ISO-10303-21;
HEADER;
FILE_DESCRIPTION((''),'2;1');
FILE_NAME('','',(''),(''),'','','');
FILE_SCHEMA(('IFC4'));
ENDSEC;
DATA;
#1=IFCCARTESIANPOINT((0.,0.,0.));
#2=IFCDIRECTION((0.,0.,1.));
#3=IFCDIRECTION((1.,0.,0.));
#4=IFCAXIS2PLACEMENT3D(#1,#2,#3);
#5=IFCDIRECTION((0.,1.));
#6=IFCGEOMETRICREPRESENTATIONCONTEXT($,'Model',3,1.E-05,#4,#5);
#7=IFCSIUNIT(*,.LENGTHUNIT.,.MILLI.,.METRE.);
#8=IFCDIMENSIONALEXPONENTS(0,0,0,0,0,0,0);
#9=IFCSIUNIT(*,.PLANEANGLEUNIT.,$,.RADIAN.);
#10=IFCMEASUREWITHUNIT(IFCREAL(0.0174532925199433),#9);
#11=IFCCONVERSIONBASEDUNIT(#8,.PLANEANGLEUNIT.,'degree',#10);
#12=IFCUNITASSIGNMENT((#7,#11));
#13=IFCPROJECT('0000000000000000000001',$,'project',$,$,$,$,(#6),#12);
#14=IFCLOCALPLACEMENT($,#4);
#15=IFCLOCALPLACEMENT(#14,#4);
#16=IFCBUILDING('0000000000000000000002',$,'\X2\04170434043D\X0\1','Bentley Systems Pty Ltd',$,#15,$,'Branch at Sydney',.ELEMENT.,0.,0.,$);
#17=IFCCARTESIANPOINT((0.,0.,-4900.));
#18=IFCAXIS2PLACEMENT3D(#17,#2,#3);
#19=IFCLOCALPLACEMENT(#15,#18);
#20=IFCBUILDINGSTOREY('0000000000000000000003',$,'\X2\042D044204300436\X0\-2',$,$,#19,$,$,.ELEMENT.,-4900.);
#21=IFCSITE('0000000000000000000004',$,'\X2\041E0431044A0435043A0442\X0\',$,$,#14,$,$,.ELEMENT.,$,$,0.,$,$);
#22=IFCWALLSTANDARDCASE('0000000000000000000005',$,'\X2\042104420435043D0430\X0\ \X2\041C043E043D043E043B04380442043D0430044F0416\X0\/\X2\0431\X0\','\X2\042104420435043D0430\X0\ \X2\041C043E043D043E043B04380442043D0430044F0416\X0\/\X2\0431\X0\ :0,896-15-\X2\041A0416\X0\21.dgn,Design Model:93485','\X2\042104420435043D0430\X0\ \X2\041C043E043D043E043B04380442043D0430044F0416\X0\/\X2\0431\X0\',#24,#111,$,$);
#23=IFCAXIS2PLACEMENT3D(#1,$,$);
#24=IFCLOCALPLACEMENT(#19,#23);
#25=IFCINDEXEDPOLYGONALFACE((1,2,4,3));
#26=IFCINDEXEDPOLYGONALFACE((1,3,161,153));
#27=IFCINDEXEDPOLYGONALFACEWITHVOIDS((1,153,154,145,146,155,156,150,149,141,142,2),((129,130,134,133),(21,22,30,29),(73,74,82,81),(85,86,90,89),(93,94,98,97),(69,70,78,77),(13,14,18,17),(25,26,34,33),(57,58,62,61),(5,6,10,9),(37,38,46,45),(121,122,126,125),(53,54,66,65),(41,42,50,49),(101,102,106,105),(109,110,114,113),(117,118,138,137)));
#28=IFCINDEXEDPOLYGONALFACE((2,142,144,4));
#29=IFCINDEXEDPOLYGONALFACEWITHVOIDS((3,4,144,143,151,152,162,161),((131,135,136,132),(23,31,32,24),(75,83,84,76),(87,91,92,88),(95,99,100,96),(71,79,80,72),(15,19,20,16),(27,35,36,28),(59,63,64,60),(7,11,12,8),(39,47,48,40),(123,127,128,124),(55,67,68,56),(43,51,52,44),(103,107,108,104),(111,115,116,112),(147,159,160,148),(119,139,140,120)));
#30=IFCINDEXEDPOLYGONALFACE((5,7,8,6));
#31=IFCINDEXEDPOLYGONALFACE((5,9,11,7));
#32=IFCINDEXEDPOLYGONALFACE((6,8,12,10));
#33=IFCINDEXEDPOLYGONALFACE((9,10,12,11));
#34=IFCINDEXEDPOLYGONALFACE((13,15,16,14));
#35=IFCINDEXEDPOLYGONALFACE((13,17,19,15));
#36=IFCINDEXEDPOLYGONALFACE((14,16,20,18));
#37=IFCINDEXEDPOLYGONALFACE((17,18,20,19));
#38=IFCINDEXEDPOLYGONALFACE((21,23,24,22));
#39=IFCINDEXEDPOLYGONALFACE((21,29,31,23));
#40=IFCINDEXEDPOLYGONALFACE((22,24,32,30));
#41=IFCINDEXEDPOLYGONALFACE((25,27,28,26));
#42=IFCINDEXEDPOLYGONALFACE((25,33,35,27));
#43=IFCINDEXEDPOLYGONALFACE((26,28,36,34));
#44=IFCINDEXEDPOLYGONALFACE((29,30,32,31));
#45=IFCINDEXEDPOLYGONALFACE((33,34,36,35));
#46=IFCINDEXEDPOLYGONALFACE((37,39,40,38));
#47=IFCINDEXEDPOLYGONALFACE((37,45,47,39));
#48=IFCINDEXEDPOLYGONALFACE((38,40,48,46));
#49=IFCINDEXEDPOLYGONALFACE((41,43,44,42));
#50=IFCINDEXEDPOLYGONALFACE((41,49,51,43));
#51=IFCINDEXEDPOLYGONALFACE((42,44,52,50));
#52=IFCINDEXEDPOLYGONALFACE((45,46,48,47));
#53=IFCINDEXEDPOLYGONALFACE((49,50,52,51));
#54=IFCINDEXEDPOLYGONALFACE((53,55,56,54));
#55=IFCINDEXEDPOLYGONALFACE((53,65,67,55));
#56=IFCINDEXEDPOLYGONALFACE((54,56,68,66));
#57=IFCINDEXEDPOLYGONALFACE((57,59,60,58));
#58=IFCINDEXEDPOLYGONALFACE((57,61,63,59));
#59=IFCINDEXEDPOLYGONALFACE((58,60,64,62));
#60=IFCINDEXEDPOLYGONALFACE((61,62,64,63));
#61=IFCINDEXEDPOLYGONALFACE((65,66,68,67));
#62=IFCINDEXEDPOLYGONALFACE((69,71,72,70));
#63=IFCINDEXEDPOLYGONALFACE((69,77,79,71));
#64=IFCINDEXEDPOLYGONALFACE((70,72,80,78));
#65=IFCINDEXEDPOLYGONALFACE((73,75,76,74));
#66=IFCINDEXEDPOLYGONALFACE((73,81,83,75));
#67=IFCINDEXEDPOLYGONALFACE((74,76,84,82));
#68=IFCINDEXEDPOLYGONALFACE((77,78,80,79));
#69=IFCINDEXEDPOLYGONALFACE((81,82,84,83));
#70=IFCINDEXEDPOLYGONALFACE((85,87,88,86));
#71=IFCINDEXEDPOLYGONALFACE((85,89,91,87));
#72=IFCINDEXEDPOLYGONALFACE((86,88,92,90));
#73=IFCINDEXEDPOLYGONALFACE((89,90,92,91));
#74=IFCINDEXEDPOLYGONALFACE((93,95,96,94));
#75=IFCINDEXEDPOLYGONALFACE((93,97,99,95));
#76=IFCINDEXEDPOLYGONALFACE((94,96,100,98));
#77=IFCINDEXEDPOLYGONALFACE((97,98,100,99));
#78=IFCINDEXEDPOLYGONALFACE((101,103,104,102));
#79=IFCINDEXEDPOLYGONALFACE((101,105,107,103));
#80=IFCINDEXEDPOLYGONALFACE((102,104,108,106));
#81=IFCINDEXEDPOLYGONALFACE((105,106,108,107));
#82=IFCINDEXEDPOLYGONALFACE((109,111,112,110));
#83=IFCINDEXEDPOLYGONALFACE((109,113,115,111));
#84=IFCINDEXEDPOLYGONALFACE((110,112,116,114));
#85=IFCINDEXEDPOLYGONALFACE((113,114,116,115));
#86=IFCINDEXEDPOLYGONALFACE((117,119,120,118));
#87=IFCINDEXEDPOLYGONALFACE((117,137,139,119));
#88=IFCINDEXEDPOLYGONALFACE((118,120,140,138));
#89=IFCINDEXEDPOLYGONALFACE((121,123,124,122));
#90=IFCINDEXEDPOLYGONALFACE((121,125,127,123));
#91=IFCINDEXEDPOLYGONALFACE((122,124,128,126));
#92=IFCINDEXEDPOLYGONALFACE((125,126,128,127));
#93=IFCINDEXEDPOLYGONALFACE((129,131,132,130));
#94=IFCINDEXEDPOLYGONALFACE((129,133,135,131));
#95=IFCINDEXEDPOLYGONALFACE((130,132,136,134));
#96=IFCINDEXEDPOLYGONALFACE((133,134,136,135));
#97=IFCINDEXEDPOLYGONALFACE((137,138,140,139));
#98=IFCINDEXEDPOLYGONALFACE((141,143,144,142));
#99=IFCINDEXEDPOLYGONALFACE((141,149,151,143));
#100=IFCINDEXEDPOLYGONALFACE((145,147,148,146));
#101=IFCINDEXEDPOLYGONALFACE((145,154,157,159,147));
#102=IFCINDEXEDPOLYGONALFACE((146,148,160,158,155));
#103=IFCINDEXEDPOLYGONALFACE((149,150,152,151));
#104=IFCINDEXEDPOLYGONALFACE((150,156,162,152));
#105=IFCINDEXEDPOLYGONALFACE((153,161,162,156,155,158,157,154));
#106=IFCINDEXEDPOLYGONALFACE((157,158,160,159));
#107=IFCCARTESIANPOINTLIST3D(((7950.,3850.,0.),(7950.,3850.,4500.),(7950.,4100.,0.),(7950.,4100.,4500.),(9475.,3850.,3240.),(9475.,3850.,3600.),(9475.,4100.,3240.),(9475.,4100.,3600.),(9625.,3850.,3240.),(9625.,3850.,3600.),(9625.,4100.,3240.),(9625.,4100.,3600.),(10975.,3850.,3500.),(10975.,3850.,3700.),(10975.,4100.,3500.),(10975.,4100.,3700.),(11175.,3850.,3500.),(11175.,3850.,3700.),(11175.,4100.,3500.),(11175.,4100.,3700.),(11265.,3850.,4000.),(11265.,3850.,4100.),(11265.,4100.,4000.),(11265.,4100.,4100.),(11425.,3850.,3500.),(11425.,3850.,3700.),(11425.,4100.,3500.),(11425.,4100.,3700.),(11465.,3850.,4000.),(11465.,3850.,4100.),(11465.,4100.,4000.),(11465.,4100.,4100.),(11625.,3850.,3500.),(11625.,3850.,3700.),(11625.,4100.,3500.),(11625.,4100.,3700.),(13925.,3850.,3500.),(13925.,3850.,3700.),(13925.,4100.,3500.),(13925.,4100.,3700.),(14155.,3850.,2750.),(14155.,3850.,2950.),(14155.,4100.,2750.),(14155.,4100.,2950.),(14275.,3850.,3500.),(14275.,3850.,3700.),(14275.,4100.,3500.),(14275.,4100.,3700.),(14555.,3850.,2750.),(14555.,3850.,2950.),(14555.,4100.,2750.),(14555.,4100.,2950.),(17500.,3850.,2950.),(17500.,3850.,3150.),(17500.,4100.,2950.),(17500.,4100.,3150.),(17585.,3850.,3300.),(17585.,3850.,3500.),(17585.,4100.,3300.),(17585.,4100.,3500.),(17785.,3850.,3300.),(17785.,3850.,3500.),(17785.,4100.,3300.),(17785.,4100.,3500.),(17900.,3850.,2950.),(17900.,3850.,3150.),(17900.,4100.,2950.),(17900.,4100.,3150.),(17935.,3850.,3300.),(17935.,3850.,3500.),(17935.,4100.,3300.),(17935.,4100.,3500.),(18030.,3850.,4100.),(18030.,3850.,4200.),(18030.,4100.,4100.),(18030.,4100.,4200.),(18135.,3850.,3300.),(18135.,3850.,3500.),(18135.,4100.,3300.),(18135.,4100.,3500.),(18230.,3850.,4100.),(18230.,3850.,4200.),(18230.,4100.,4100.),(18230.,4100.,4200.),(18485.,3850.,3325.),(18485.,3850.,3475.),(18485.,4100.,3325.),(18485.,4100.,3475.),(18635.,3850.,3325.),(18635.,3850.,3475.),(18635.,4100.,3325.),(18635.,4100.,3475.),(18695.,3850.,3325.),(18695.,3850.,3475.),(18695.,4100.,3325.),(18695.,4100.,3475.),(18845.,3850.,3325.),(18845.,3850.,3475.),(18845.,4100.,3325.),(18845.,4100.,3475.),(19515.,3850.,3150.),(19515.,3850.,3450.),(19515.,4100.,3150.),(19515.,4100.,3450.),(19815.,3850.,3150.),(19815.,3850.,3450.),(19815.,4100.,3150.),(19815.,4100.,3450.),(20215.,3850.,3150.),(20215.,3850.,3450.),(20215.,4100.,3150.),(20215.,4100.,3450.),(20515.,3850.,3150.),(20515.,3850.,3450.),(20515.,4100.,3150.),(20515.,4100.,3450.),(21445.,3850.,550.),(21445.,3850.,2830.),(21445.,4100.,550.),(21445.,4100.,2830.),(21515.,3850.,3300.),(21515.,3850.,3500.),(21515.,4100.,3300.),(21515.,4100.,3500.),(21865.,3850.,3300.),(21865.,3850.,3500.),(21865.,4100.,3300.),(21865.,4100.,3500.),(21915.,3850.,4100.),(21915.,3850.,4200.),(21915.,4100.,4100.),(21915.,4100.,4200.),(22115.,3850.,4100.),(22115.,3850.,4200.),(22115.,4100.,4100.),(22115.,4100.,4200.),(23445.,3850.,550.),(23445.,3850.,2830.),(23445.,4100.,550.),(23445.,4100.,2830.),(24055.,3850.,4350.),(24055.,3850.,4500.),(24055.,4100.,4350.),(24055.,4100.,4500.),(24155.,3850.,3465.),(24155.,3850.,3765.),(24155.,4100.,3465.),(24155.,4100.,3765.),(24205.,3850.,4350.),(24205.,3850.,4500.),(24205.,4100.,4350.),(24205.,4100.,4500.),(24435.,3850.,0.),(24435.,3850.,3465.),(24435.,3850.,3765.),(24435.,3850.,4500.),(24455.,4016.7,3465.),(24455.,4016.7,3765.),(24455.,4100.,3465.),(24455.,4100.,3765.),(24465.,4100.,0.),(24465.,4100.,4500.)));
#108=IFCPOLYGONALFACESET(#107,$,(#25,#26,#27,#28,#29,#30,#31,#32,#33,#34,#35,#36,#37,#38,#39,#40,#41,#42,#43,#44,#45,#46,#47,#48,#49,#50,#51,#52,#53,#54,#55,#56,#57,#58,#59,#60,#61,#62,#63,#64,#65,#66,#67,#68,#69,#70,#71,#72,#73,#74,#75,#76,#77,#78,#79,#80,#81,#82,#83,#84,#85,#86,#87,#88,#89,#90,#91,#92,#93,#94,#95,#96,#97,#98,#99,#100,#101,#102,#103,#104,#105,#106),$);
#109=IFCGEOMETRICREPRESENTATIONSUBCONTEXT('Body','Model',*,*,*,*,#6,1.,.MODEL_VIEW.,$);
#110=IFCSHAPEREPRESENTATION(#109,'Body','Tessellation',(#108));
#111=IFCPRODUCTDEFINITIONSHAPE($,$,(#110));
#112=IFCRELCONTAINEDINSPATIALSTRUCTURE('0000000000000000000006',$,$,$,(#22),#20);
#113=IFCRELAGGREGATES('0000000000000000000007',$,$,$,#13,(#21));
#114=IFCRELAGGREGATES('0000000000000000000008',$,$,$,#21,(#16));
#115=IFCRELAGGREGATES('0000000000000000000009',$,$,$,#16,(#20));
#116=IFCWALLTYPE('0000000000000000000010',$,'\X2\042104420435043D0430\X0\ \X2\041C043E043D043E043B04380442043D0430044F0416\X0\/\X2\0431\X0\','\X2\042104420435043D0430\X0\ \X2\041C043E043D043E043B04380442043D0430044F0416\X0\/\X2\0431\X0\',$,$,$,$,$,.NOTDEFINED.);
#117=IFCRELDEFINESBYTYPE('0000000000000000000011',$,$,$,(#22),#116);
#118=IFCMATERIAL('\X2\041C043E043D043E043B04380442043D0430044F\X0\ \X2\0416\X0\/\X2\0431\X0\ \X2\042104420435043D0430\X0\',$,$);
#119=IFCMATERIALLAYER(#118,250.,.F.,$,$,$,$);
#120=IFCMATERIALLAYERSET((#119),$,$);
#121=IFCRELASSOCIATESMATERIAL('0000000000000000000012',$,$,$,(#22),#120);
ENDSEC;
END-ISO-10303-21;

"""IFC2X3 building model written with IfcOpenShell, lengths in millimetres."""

from ifc_helpers import new_model, entity, si_unit, converted_unit, direction, frame, frame_2d, origin_with_axes, place, context, subcontext, project, spatial, polyline, rectangle, outline, extrude, material, layer, layer_set, layer_usage, type_object, element, save


model = new_model("IFC2X3")

# Units and contexts
model_context = context("Model", 3, precision=1e-05, world=origin_with_axes(), true_north=direction((0.0, 1.0)))
body_context = subcontext(model_context, "Body", "Model", "MODEL_VIEW", scale=1.0)
ifc_project = project(units=[si_unit("LENGTHUNIT", "METRE", prefix="MILLI"), converted_unit("PLANEANGLEUNIT", "degree", entity("IfcReal", 0.0174532925199433), si_unit("PLANEANGLEUNIT", "RADIAN"), dimensions=[0, 0, 0, 0, 0, 0, 0])], contexts=[model_context])

# Site, building, storey
site_placement = place(None, origin_with_axes())
site = spatial("IfcSite", under=ifc_project, at=site_placement, Name="Объект", CompositionType="ELEMENT", RefElevation=0.0)
building_placement = place(site_placement, origin_with_axes())
building = spatial("IfcBuilding", under=site, at=building_placement, Name="Здн1", Description="Bentley Systems Pty Ltd", LongName="Branch at Sydney", CompositionType="ELEMENT", ElevationOfRefHeight=0.0, ElevationOfTerrain=0.0)
storey_placement = place(building_placement, frame((0.0, 0.0, -4900.0), z_axis=(0.0, 0.0, 1.0), x_axis=(1.0, 0.0, 0.0)))
storey = spatial("IfcBuildingStorey", under=building, at=storey_placement, Name="Этаж-2", CompositionType="ELEMENT", Elevation=-4900.0)

# Wall, openings
ifc_material = material(Name="Монолитная Ж/б Стена")
ifc_layer_1 = layer(ifc_material, 250.0, ventilated=False)
ifc_layer_set_1 = layer_set([ifc_layer_1])
ifc_layer_usage_1 = layer_usage(ifc_layer_set_1, "AXIS2", "POSITIVE", 0.0)
wall_type = type_object("IfcWallType", Name="Стена МонолитнаяЖ/б", Description="Стена МонолитнаяЖ/б", PredefinedType="NOTDEFINED")
wall_1_placement = place(storey_placement, frame((7950.0, 3850.0, 0.0), z_axis=(0.0, 0.0, 1.0), x_axis=(1.0, 0.0, 0.0)))
wall_1 = element("IfcWallStandardCase", 1, at=wall_1_placement, inside=storey, type_object=wall_type, material=ifc_layer_usage_1, Name="Стена МонолитнаяЖ/б", Description="Стена МонолитнаяЖ/б :0,896-15-КЖ21.dgn,Design Model:93485", ObjectType="Стена МонолитнаяЖ/б", context=body_context, shape_type="SweptSolid", body=[
    extrude(outline(polyline([(16515.0, 250.0), (0.0, 250.0), (0.0, 0.0), (16485.0, 0.0), (16515.0, 250.0)])), origin_with_axes(), (0.0, 0.0, 1.0), 4500.0),
])
opening_1_placement = place(wall_1_placement, frame((13495.0, 0.0, 550.0), z_axis=(0.0, 0.0, 1.0), x_axis=(1.0, 0.0, 0.0)))
element("IfcOpeningElement", 2, at=opening_1_placement, cuts=wall_1, ObjectType="Opening", context=body_context, shape_type="SweptSolid", body=[
    extrude(rectangle(XDim=2280.0, YDim=2000.0, at=frame_2d((-1000.0, 1140.0), x_axis=(0.0, -1.0))), frame((0.0, 0.0, 0.0), z_axis=(0.0, 1.0, 0.0), x_axis=(-1.0, 0.0, 0.0)), (0.0, 0.0, 1.0), 250.0),
])
opening_2_placement = place(wall_1_placement, frame((1525.0, 0.0, 3240.0), z_axis=(0.0, 0.0, 1.0), x_axis=(1.0, 0.0, 0.0)))
element("IfcOpeningElement", 3, at=opening_2_placement, cuts=wall_1, ObjectType="Opening", context=body_context, shape_type="SweptSolid", body=[
    extrude(rectangle(XDim=360.0, YDim=150.0, at=frame_2d((-75.0, 180.0), x_axis=(0.0, -1.0))), frame((0.0, 0.0, 0.0), z_axis=(0.0, 1.0, 0.0), x_axis=(-1.0, 0.0, 0.0)), (0.0, 0.0, 1.0), 250.0),
])
opening_3_placement = place(wall_1_placement, frame((3025.0, 0.0, 3500.0), z_axis=(0.0, 0.0, 1.0), x_axis=(1.0, 0.0, 0.0)))
element("IfcOpeningElement", 4, at=opening_3_placement, cuts=wall_1, ObjectType="Opening", context=body_context, shape_type="SweptSolid", body=[
    extrude(rectangle(XDim=200.0, YDim=200.0, at=frame_2d((-100.0, 100.0), x_axis=(0.0, -1.0))), frame((0.0, 0.0, 0.0), z_axis=(0.0, 1.0, 0.0), x_axis=(-1.0, 0.0, 0.0)), (0.0, 0.0, 1.0), 250.0),
])
opening_4_placement = place(wall_1_placement, frame((3475.0, 0.0, 3500.0), z_axis=(0.0, 0.0, 1.0), x_axis=(1.0, 0.0, 0.0)))
element("IfcOpeningElement", 5, at=opening_4_placement, cuts=wall_1, ObjectType="Opening", context=body_context, shape_type="SweptSolid", body=[
    extrude(rectangle(XDim=200.0, YDim=200.0, at=frame_2d((-100.0, 100.0), x_axis=(0.0, -1.0))), frame((0.0, 0.0, 0.0), z_axis=(0.0, 1.0, 0.0), x_axis=(-1.0, 0.0, 0.0)), (0.0, 0.0, 1.0), 250.0),
])
opening_5_placement = place(wall_1_placement, frame((5975.0, 0.0, 3500.0), z_axis=(0.0, 0.0, 1.0), x_axis=(1.0, 0.0, 0.0)))
element("IfcOpeningElement", 6, at=opening_5_placement, cuts=wall_1, ObjectType="Opening", context=body_context, shape_type="SweptSolid", body=[
    extrude(rectangle(XDim=200.0, YDim=350.0, at=frame_2d((-175.0, 100.0), x_axis=(0.0, -1.0))), frame((0.0, 0.0, 0.0), z_axis=(0.0, 1.0, 0.0), x_axis=(-1.0, 0.0, 0.0)), (0.0, 0.0, 1.0), 250.0),
])
opening_6_placement = place(wall_1_placement, frame((3315.0, 0.0, 4000.0), z_axis=(0.0, 0.0, 1.0), x_axis=(1.0, 0.0, 0.0)))
element("IfcOpeningElement", 7, at=opening_6_placement, cuts=wall_1, ObjectType="Opening", context=body_context, shape_type="SweptSolid", body=[
    extrude(rectangle(XDim=100.0, YDim=200.0, at=frame_2d((-100.0, 50.0), x_axis=(0.0, -1.0))), frame((0.0, 0.0, 0.0), z_axis=(0.0, 1.0, 0.0), x_axis=(-1.0, 0.0, 0.0)), (0.0, 0.0, 1.0), 250.0),
])
opening_7_placement = place(wall_1_placement, frame((6205.0, 0.0, 2750.0), z_axis=(0.0, 0.0, 1.0), x_axis=(1.0, 0.0, 0.0)))
element("IfcOpeningElement", 8, at=opening_7_placement, cuts=wall_1, ObjectType="Opening", context=body_context, shape_type="SweptSolid", body=[
    extrude(rectangle(XDim=200.0, YDim=400.0, at=frame_2d((-200.0, 100.0), x_axis=(0.0, -1.0))), frame((0.0, 0.0, 0.0), z_axis=(0.0, 1.0, 0.0), x_axis=(-1.0, 0.0, 0.0)), (0.0, 0.0, 1.0), 250.0),
])
opening_8_placement = place(wall_1_placement, frame((9635.0, 0.0, 3300.0), z_axis=(0.0, 0.0, 1.0), x_axis=(1.0, 0.0, 0.0)))
element("IfcOpeningElement", 9, at=opening_8_placement, cuts=wall_1, ObjectType="Opening", context=body_context, shape_type="SweptSolid", body=[
    extrude(rectangle(XDim=200.0, YDim=200.0, at=frame_2d((-100.0, 100.0), x_axis=(0.0, -1.0))), frame((0.0, 0.0, 0.0), z_axis=(0.0, 1.0, 0.0), x_axis=(-1.0, 0.0, 0.0)), (0.0, 0.0, 1.0), 250.0),
])
opening_9_placement = place(wall_1_placement, frame((9985.0, 0.0, 3300.0), z_axis=(0.0, 0.0, 1.0), x_axis=(1.0, 0.0, 0.0)))
element("IfcOpeningElement", 10, at=opening_9_placement, cuts=wall_1, ObjectType="Opening", context=body_context, shape_type="SweptSolid", body=[
    extrude(rectangle(XDim=200.0, YDim=200.0, at=frame_2d((-100.0, 100.0), x_axis=(0.0, -1.0))), frame((0.0, 0.0, 0.0), z_axis=(0.0, 1.0, 0.0), x_axis=(-1.0, 0.0, 0.0)), (0.0, 0.0, 1.0), 250.0),
])
opening_10_placement = place(wall_1_placement, frame((10535.0, 0.0, 3325.0), z_axis=(0.0, 0.0, 1.0), x_axis=(1.0, 0.0, 0.0)))
element("IfcOpeningElement", 11, at=opening_10_placement, cuts=wall_1, ObjectType="Opening", context=body_context, shape_type="SweptSolid", body=[
    extrude(rectangle(XDim=150.0, YDim=150.0, at=frame_2d((-75.0, 75.0), x_axis=(0.0, -1.0))), frame((0.0, 0.0, 0.0), z_axis=(0.0, 1.0, 0.0), x_axis=(-1.0, 0.0, 0.0)), (0.0, 0.0, 1.0), 250.0),
])
opening_11_placement = place(wall_1_placement, frame((10745.0, 0.0, 3325.0), z_axis=(0.0, 0.0, 1.0), x_axis=(1.0, 0.0, 0.0)))
element("IfcOpeningElement", 12, at=opening_11_placement, cuts=wall_1, ObjectType="Opening", context=body_context, shape_type="SweptSolid", body=[
    extrude(rectangle(XDim=150.0, YDim=150.0, at=frame_2d((-75.0, 75.0), x_axis=(0.0, -1.0))), frame((0.0, 0.0, 0.0), z_axis=(0.0, 1.0, 0.0), x_axis=(-1.0, 0.0, 0.0)), (0.0, 0.0, 1.0), 250.0),
])
opening_12_placement = place(wall_1_placement, frame((11565.0, 0.0, 3150.0), z_axis=(0.0, 0.0, 1.0), x_axis=(1.0, 0.0, 0.0)))
element("IfcOpeningElement", 13, at=opening_12_placement, cuts=wall_1, ObjectType="Opening", context=body_context, shape_type="SweptSolid", body=[
    extrude(rectangle(XDim=300.0, YDim=300.0, at=frame_2d((-150.0, 150.0), x_axis=(0.0, -1.0))), frame((0.0, 0.0, 0.0), z_axis=(0.0, 1.0, 0.0), x_axis=(-1.0, 0.0, 0.0)), (0.0, 0.0, 1.0), 250.0),
])
opening_13_placement = place(wall_1_placement, frame((12265.0, 0.0, 3150.0), z_axis=(0.0, 0.0, 1.0), x_axis=(1.0, 0.0, 0.0)))
element("IfcOpeningElement", 14, at=opening_13_placement, cuts=wall_1, ObjectType="Opening", context=body_context, shape_type="SweptSolid", body=[
    extrude(rectangle(XDim=300.0, YDim=300.0, at=frame_2d((-150.0, 150.0), x_axis=(0.0, -1.0))), frame((0.0, 0.0, 0.0), z_axis=(0.0, 1.0, 0.0), x_axis=(-1.0, 0.0, 0.0)), (0.0, 0.0, 1.0), 250.0),
])
opening_14_placement = place(wall_1_placement, frame((13565.0, 0.0, 3300.0), z_axis=(0.0, 0.0, 1.0), x_axis=(1.0, 0.0, 0.0)))
element("IfcOpeningElement", 15, at=opening_14_placement, cuts=wall_1, ObjectType="Opening", context=body_context, shape_type="SweptSolid", body=[
    extrude(rectangle(XDim=200.0, YDim=350.0, at=frame_2d((-175.0, 100.0), x_axis=(0.0, -1.0))), frame((0.0, 0.0, 0.0), z_axis=(0.0, 1.0, 0.0), x_axis=(-1.0, 0.0, 0.0)), (0.0, 0.0, 1.0), 250.0),
])
opening_15_placement = place(wall_1_placement, frame((16205.0, 0.0, 3465.0), z_axis=(0.0, 0.0, 1.0), x_axis=(1.0, 0.0, 0.0)))
element("IfcOpeningElement", 16, at=opening_15_placement, cuts=wall_1, ObjectType="Opening", context=body_context, shape_type="SweptSolid", body=[
    extrude(rectangle(XDim=300.0, YDim=300.0, at=frame_2d((-150.0, 150.0), x_axis=(0.0, -1.0))), frame((0.0, 0.0, 0.0), z_axis=(0.0, 1.0, 0.0), x_axis=(-1.0, 0.0, 0.0)), (0.0, 0.0, 1.0), 250.0),
])
opening_16_placement = place(wall_1_placement, frame((9550.0, 0.0, 2950.0), z_axis=(0.0, 0.0, 1.0), x_axis=(1.0, 0.0, 0.0)))
element("IfcOpeningElement", 17, at=opening_16_placement, cuts=wall_1, ObjectType="Opening", context=body_context, shape_type="SweptSolid", body=[
    extrude(rectangle(XDim=200.0, YDim=400.0, at=frame_2d((-200.0, 100.0), x_axis=(0.0, -1.0))), frame((0.0, 0.0, 0.0), z_axis=(0.0, 1.0, 0.0), x_axis=(-1.0, 0.0, 0.0)), (0.0, 0.0, 1.0), 250.0),
])
opening_17_placement = place(wall_1_placement, frame((10080.0, 0.0, 4100.0), z_axis=(0.0, 0.0, 1.0), x_axis=(1.0, 0.0, 0.0)))
element("IfcOpeningElement", 18, at=opening_17_placement, cuts=wall_1, ObjectType="Opening", context=body_context, shape_type="SweptSolid", body=[
    extrude(rectangle(XDim=100.0, YDim=200.0, at=frame_2d((-100.0, 50.0), x_axis=(0.0, -1.0))), frame((0.0, 0.0, 0.0), z_axis=(0.0, 1.0, 0.0), x_axis=(-1.0, 0.0, 0.0)), (0.0, 0.0, 1.0), 250.0),
])
opening_18_placement = place(wall_1_placement, frame((13965.0, 0.0, 4100.0), z_axis=(0.0, 0.0, 1.0), x_axis=(1.0, 0.0, 0.0)))
element("IfcOpeningElement", 19, at=opening_18_placement, cuts=wall_1, ObjectType="Opening", context=body_context, shape_type="SweptSolid", body=[
    extrude(rectangle(XDim=100.0, YDim=200.0, at=frame_2d((-100.0, 50.0), x_axis=(0.0, -1.0))), frame((0.0, 0.0, 0.0), z_axis=(0.0, 1.0, 0.0), x_axis=(-1.0, 0.0, 0.0)), (0.0, 0.0, 1.0), 250.0),
])
opening_19_placement = place(wall_1_placement, frame((16105.0, 0.0, 4350.0), z_axis=(0.0, 0.0, 1.0), x_axis=(1.0, 0.0, 0.0)))
element("IfcOpeningElement", 20, at=opening_19_placement, cuts=wall_1, ObjectType="Opening", context=body_context, shape_type="SweptSolid", body=[
    extrude(rectangle(XDim=150.0, YDim=150.0, at=frame_2d((-75.0, 75.0), x_axis=(0.0, -1.0))), frame((0.0, 0.0, 0.0), z_axis=(0.0, 1.0, 0.0), x_axis=(-1.0, 0.0, 0.0)), (0.0, 0.0, 1.0), 250.0),
])

save(model, "model.ifc")
